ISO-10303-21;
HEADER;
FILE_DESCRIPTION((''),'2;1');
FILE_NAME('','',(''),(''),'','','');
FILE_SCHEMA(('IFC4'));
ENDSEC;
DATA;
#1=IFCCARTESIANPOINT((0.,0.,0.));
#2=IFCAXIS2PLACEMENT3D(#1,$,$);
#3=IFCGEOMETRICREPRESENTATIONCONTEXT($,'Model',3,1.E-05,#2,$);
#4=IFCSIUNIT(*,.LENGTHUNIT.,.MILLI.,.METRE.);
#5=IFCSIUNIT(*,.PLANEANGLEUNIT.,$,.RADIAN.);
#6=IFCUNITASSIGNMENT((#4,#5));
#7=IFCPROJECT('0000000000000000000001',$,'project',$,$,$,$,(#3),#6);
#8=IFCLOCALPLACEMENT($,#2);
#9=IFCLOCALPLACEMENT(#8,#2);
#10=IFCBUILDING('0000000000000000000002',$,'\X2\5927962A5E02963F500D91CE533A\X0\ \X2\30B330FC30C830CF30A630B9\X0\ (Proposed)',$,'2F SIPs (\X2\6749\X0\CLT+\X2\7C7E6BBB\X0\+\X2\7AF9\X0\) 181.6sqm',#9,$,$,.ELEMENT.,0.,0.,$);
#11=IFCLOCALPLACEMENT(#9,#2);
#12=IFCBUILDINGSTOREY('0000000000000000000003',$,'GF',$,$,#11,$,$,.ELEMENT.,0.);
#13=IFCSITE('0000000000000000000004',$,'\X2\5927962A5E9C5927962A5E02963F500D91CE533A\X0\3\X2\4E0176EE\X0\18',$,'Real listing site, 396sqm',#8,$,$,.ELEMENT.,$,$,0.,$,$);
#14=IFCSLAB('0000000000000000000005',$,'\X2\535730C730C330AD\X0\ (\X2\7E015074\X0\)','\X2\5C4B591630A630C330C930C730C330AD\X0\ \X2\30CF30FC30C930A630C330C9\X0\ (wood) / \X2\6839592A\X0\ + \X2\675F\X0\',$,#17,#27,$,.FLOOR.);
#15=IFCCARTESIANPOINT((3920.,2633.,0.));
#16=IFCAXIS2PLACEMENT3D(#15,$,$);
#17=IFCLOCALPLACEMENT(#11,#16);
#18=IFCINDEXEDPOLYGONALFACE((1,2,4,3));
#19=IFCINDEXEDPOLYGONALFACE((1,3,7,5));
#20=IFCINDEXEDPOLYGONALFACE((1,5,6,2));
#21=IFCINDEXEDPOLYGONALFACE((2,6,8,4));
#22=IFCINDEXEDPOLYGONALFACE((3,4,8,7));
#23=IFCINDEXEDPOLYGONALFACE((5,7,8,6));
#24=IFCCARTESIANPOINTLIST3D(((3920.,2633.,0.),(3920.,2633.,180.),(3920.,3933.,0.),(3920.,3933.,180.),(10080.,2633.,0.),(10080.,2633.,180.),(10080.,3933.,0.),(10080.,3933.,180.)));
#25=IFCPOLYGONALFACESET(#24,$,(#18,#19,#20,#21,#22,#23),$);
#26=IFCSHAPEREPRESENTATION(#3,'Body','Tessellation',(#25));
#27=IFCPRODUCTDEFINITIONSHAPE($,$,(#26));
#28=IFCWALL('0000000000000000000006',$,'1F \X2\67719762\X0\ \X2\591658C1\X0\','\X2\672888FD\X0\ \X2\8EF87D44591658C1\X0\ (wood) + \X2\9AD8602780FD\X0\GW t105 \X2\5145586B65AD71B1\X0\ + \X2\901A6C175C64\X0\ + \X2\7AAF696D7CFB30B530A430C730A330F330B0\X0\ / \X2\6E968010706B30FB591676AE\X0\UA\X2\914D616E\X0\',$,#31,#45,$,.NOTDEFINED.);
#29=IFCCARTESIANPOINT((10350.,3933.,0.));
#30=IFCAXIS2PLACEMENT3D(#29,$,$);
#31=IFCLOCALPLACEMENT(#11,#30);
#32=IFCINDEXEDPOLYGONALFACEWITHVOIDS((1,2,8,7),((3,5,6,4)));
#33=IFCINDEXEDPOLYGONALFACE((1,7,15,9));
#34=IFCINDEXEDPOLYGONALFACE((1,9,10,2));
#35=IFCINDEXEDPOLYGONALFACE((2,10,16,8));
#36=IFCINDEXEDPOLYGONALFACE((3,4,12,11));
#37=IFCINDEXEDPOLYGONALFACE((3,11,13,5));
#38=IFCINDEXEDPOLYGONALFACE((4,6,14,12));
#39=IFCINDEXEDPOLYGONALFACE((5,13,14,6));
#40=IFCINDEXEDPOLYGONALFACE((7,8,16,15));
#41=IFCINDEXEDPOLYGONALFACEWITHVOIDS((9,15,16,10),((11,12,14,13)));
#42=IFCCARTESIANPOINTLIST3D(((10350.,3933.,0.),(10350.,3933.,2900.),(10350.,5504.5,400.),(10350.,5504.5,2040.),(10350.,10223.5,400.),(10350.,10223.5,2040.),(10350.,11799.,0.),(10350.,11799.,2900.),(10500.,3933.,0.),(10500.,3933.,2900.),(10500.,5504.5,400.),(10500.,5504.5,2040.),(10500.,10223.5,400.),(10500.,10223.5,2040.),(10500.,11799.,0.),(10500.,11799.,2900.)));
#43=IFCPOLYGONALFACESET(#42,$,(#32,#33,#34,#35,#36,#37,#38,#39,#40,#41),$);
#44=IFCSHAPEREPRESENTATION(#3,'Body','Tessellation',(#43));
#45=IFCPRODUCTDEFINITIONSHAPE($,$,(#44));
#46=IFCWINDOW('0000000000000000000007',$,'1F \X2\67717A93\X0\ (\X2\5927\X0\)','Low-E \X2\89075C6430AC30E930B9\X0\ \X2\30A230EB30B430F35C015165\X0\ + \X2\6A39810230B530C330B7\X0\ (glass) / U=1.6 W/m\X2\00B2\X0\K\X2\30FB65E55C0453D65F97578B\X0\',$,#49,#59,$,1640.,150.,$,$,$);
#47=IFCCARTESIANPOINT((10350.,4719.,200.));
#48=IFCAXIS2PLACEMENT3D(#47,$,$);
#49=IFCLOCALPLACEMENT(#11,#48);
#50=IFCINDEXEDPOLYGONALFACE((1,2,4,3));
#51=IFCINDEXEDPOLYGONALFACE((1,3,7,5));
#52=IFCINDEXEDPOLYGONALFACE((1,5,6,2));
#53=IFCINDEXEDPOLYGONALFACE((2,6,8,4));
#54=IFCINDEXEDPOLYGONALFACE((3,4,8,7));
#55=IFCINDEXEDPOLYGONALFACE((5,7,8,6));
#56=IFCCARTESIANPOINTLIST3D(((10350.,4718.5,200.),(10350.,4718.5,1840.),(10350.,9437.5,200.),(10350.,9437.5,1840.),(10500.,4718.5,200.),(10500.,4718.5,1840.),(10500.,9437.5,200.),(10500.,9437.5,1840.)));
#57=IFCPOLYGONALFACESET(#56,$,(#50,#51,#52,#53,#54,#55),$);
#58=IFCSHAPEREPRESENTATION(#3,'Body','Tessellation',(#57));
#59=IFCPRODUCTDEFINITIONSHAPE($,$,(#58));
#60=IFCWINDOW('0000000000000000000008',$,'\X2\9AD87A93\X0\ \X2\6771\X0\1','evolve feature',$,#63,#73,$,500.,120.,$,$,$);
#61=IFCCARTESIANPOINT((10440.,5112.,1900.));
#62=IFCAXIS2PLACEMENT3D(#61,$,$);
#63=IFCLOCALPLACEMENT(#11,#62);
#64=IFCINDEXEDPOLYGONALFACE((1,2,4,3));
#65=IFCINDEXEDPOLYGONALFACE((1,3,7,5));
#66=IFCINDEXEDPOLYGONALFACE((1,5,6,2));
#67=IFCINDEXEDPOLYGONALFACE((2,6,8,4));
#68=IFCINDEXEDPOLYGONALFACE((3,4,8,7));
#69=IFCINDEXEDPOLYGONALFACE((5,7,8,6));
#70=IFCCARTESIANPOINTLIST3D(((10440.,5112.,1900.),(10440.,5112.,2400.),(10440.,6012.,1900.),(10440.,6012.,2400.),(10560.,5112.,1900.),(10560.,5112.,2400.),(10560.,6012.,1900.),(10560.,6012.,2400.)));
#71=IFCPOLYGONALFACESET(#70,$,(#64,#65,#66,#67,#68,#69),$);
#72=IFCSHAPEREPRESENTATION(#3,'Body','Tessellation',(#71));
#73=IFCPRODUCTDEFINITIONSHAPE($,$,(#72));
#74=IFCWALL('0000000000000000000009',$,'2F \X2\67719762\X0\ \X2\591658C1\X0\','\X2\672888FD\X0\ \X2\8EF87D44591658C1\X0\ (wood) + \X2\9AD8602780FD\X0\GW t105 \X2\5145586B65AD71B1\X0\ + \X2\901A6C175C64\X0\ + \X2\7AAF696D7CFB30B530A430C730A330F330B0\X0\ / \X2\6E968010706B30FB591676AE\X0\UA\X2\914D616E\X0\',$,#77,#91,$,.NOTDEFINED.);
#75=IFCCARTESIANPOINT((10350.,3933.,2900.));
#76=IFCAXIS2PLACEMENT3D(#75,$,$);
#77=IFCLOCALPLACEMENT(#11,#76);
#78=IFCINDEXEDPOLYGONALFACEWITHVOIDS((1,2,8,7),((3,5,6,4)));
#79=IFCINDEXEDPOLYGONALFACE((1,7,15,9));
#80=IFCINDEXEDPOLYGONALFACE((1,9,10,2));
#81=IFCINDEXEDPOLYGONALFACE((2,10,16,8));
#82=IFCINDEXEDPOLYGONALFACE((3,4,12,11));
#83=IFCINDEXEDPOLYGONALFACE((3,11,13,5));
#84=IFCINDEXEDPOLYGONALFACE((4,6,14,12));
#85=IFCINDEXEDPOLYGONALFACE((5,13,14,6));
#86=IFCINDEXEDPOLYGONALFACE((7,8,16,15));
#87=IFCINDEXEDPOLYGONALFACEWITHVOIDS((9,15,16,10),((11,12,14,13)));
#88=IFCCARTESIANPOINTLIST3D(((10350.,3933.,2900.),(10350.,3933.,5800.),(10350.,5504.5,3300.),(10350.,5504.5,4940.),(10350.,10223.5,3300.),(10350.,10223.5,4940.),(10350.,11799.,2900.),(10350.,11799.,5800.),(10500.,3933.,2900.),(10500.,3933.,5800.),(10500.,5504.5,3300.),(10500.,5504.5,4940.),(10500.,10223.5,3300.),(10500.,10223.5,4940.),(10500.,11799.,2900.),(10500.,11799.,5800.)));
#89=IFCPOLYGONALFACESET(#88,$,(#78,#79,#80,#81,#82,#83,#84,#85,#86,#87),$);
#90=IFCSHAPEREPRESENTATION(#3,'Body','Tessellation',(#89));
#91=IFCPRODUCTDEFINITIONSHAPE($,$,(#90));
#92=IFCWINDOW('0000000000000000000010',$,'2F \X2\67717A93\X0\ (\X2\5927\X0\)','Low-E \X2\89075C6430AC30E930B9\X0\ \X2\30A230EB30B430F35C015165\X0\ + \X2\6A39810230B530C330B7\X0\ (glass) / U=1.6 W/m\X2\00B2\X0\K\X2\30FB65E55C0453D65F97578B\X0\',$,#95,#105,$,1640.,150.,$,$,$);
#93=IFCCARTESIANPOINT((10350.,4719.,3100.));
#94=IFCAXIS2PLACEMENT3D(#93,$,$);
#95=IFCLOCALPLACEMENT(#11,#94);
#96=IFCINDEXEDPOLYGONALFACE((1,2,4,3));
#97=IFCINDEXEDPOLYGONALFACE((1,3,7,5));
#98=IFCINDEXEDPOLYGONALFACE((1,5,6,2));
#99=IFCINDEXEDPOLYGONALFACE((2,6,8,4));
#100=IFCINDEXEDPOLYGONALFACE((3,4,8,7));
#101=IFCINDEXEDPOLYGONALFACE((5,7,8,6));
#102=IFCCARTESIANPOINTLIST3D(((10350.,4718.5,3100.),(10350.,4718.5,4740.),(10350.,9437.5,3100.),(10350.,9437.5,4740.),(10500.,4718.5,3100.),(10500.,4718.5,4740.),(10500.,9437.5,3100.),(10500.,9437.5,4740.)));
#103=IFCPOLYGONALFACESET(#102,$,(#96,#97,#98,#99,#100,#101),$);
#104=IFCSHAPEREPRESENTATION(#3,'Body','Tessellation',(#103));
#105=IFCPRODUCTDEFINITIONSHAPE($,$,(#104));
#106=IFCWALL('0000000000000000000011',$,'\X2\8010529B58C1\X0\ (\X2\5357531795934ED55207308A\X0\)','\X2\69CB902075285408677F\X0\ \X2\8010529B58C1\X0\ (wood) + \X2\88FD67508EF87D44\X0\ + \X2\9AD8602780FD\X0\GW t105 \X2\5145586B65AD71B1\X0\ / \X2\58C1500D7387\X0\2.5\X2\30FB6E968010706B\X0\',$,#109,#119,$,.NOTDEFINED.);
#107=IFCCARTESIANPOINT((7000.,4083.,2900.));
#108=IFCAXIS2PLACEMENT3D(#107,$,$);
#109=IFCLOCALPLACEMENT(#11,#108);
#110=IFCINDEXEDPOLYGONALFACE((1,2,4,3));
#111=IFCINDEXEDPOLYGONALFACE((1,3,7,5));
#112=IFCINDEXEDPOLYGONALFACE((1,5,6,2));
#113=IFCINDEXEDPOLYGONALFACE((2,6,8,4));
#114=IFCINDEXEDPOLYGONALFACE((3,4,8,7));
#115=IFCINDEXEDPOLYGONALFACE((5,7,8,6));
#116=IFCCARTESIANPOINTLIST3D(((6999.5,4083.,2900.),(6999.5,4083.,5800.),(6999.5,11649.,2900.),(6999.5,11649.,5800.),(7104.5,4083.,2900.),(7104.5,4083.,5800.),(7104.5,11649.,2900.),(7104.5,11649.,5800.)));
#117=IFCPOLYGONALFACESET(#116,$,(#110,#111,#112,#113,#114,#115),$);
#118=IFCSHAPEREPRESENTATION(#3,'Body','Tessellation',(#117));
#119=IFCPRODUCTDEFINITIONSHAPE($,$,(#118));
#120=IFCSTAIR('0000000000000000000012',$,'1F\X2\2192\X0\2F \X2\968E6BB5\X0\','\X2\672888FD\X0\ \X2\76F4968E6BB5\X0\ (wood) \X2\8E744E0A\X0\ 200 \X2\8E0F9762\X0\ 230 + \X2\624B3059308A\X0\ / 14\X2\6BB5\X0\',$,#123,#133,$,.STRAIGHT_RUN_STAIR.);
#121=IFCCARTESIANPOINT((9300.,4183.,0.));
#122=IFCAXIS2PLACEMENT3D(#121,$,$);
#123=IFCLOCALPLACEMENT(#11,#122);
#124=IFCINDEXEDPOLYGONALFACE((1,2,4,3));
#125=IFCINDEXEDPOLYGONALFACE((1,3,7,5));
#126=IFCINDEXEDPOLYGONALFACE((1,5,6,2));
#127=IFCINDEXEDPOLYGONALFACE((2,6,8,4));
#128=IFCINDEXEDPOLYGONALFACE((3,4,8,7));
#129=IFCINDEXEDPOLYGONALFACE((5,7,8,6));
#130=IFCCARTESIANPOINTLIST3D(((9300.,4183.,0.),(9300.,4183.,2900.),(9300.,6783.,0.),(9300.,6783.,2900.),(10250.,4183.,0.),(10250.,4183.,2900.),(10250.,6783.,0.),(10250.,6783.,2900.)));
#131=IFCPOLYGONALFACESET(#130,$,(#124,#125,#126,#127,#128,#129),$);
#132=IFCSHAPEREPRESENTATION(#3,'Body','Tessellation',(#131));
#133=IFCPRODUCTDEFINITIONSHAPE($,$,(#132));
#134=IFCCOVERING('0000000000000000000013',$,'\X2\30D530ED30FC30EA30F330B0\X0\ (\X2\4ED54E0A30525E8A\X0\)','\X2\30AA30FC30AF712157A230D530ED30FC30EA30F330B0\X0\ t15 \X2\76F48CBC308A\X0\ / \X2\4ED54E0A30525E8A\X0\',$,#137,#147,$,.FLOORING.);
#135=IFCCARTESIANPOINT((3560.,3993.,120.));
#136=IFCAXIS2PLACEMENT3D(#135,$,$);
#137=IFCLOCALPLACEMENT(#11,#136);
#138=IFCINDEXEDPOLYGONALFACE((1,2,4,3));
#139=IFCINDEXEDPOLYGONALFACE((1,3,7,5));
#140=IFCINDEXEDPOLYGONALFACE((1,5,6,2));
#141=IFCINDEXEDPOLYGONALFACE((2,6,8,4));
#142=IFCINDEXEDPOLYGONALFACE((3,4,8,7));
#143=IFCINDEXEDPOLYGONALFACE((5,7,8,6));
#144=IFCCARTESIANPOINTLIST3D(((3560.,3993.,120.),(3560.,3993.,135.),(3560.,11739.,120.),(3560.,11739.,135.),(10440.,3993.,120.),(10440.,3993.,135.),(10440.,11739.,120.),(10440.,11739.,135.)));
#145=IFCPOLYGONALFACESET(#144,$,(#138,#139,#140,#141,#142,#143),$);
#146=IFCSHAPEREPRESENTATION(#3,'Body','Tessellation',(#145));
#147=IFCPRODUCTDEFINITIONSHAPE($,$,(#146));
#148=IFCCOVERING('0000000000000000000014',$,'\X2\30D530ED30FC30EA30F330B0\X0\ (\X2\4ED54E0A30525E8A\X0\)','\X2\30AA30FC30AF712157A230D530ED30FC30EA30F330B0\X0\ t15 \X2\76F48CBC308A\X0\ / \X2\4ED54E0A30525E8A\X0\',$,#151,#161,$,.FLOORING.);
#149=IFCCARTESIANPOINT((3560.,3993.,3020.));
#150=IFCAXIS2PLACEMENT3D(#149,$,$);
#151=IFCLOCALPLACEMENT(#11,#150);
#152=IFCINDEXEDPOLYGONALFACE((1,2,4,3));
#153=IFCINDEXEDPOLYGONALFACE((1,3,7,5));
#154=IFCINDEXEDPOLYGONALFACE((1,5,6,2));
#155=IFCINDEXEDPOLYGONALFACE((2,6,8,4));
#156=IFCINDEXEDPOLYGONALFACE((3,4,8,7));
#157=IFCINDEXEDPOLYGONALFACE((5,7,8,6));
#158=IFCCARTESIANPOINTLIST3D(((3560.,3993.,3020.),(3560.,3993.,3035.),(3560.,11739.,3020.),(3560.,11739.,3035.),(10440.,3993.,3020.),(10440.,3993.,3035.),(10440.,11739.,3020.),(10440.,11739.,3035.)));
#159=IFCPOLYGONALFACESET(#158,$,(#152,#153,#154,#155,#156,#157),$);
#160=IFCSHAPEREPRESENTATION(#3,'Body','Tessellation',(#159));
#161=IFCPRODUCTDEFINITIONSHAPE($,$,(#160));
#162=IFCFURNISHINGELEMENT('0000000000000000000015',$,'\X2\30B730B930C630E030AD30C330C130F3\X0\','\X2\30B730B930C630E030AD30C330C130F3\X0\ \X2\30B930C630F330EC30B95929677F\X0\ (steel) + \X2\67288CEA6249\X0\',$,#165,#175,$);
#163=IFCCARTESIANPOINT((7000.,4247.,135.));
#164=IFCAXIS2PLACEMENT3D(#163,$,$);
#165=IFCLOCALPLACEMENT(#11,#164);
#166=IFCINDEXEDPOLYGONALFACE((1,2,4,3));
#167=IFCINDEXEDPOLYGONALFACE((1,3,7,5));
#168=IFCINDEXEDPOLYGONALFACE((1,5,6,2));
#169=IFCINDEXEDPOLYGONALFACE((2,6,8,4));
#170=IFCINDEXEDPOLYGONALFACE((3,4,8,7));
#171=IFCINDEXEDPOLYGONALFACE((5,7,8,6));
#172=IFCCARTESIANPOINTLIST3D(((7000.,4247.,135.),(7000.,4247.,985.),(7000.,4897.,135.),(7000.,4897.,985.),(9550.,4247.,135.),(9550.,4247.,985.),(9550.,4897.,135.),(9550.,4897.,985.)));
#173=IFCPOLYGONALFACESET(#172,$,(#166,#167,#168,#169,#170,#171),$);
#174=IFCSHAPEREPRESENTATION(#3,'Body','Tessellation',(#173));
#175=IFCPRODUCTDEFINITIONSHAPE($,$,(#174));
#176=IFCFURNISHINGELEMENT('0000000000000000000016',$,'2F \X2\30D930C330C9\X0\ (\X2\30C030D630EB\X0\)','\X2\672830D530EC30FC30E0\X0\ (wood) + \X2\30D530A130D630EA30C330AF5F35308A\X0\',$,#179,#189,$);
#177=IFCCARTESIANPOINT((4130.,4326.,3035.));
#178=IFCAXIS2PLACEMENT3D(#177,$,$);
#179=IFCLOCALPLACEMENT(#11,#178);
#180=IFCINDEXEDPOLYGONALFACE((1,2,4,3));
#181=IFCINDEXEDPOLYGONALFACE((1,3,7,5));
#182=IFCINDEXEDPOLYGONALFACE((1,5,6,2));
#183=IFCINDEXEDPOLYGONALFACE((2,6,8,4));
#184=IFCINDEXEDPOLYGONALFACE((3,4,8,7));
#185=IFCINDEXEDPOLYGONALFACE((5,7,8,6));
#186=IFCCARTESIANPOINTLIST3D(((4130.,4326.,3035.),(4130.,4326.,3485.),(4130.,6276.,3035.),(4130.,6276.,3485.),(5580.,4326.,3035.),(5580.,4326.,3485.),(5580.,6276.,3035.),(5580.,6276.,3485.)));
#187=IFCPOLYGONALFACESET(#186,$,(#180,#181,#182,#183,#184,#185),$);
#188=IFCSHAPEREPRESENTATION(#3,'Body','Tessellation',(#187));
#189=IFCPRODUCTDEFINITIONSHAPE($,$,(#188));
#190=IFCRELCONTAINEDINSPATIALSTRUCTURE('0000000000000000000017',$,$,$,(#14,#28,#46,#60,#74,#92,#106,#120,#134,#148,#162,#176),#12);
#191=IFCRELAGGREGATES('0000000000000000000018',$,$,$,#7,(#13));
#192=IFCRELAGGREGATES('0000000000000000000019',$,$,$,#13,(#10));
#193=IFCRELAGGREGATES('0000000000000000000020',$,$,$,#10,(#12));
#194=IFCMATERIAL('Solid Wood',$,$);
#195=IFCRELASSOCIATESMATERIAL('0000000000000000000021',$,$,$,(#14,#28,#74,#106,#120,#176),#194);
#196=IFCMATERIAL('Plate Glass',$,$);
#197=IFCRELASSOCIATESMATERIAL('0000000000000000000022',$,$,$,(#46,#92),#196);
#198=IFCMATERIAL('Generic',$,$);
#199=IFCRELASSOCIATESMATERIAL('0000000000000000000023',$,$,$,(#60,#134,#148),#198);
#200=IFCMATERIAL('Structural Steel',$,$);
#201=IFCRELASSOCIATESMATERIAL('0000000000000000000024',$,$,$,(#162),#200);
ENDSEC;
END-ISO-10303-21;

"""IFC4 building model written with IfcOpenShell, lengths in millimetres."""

from ifc_helpers import new_model, si_unit, frame, frame_2d, origin, place, context, project, spatial, rectangle, extrude, material, element, fill, save


model = new_model("IFC4")

# Units and contexts
model_context = context("Model", 3, precision=1e-05, world=origin())
ifc_project = project(units=[si_unit("LENGTHUNIT", "METRE", prefix="MILLI"), si_unit("PLANEANGLEUNIT", "RADIAN")], contexts=[model_context])

# Site, building, storey
site_placement = place(None, origin())
site = spatial("IfcSite", under=ifc_project, at=site_placement, Name="大阪府大阪市阿倍野区3丁目18", ObjectType="Real listing site, 396sqm", CompositionType="ELEMENT", RefElevation=0.0)
building_placement = place(site_placement, origin())
building = spatial("IfcBuilding", under=site, at=building_placement, Name="大阪市阿倍野区 コートハウス (Proposed)", ObjectType="2F SIPs (杉CLT+籾殻+竹) 181.6sqm", CompositionType="ELEMENT", ElevationOfRefHeight=0.0, ElevationOfTerrain=0.0)
storey_placement = place(building_placement, origin())
storey = spatial("IfcBuildingStorey", under=building, at=storey_placement, Name="GF", CompositionType="ELEMENT", Elevation=0.0)

# Slab
ifc_material_1 = material(Name="Solid Wood")
slab_placement = place(storey_placement, frame((3920.0, 2633.0, 0.0)))
element("IfcSlab", 1, at=slab_placement, inside=storey, material=ifc_material_1, Name="南デッキ (縁側)", Description="屋外ウッドデッキ ハードウッド (wood) / 根太 + 束", PredefinedType="FLOOR", context=model_context, shape_type="SweptSolid", body=[
    extrude(rectangle(XDim=6160.0, YDim=1300.0, at=frame_2d((3080.0, 650.0))), frame((3920.0, 2633.0, 0.0)), (0.0, 0.0, 1.0), 180.0),
])

# Wall, openings, windows
wall_1_placement = place(storey_placement, frame((10350.0, 3933.0, 0.0)))
wall_1 = element("IfcWall", 2, at=wall_1_placement, inside=storey, material=ifc_material_1, Name="1F 東面 外壁", Description="木製 軸組外壁 (wood) + 高性能GW t105 充填断熱 + 通気層 + 窯業系サイディング / 準耐火・外皮UA配慮", PredefinedType="NOTDEFINED", context=model_context, shape_type="SweptSolid", body=[
    extrude(rectangle(XDim=150.0, YDim=7866.0, at=frame_2d((75.0, 3933.0))), frame((10350.0, 3933.0, 0.0)), (0.0, 0.0, 1.0), 2900.0),
])
opening_1_placement = place(storey_placement, frame((10350.0, 4719.0, 200.0)))
opening_1 = element("IfcOpeningElement", 3, at=opening_1_placement, cuts=wall_1, PredefinedType="NOTDEFINED", context=model_context, shape_type="SweptSolid", body=[
    extrude(rectangle(XDim=150.0, YDim=4719.0, at=frame_2d((75.0, 2359.0))), frame((10350.0, 4719.0, 200.0)), (0.0, 0.0, 1.0), 1640.0),
])
opening_2_placement = place(storey_placement, frame((10440.0, 5112.0, 1900.0)))
opening_2 = element("IfcOpeningElement", 4, at=opening_2_placement, cuts=wall_1, PredefinedType="NOTDEFINED", context=model_context, shape_type="SweptSolid", body=[
    extrude(rectangle(XDim=120.0, YDim=900.0, at=frame_2d((60.0, 450.0))), frame((10440.0, 5112.0, 1900.0)), (0.0, 0.0, 1.0), 500.0),
])
ifc_material_2 = material(Name="Plate Glass")
window_1_placement = place(storey_placement, frame((10350.0, 4719.0, 200.0)))
window_1 = element("IfcWindow", 5, at=window_1_placement, inside=storey, material=ifc_material_2, Name="1F 東窓 (大)", Description="Low-E 複層ガラス アルゴン封入 + 樹脂サッシ (glass) / U=1.6 W/m²K・日射取得型", OverallHeight=1640.0, OverallWidth=150.0, context=model_context, shape_type="SweptSolid", body=[
    extrude(rectangle(XDim=150.0, YDim=4719.0, at=frame_2d((75.0, 2359.0))), frame((10350.0, 4719.0, 200.0)), (0.0, 0.0, 1.0), 1640.0),
])
fill(opening_1, window_1)
ifc_material_3 = material(Name="Generic")
window_2_placement = place(storey_placement, frame((10440.0, 5112.0, 1900.0)))
window_2 = element("IfcWindow", 6, at=window_2_placement, inside=storey, material=ifc_material_3, Name="高窓 東1", Description="evolve feature", OverallHeight=500.0, OverallWidth=120.0, context=model_context, shape_type="SweptSolid", body=[
    extrude(rectangle(XDim=120.0, YDim=900.0, at=frame_2d((60.0, 450.0))), frame((10440.0, 5112.0, 1900.0)), (0.0, 0.0, 1.0), 500.0),
])
fill(opening_2, window_2)

# Wall, opening, window
wall_2_placement = place(storey_placement, frame((10350.0, 3933.0, 2900.0)))
wall_2 = element("IfcWall", 7, at=wall_2_placement, inside=storey, material=ifc_material_1, Name="2F 東面 外壁", Description="木製 軸組外壁 (wood) + 高性能GW t105 充填断熱 + 通気層 + 窯業系サイディング / 準耐火・外皮UA配慮", PredefinedType="NOTDEFINED", context=model_context, shape_type="SweptSolid", body=[
    extrude(rectangle(XDim=150.0, YDim=7866.0, at=frame_2d((75.0, 3933.0))), frame((10350.0, 3933.0, 2900.0)), (0.0, 0.0, 1.0), 2900.0),
])
opening_3_placement = place(storey_placement, frame((10350.0, 4719.0, 3100.0)))
opening_3 = element("IfcOpeningElement", 8, at=opening_3_placement, cuts=wall_2, PredefinedType="NOTDEFINED", context=model_context, shape_type="SweptSolid", body=[
    extrude(rectangle(XDim=150.0, YDim=4719.0, at=frame_2d((75.0, 2359.0))), frame((10350.0, 4719.0, 3100.0)), (0.0, 0.0, 1.0), 1640.0),
])
window_3_placement = place(storey_placement, frame((10350.0, 4719.0, 3100.0)))
window_3 = element("IfcWindow", 9, at=window_3_placement, inside=storey, material=ifc_material_2, Name="2F 東窓 (大)", Description="Low-E 複層ガラス アルゴン封入 + 樹脂サッシ (glass) / U=1.6 W/m²K・日射取得型", OverallHeight=1640.0, OverallWidth=150.0, context=model_context, shape_type="SweptSolid", body=[
    extrude(rectangle(XDim=150.0, YDim=4719.0, at=frame_2d((75.0, 2359.0))), frame((10350.0, 4719.0, 3100.0)), (0.0, 0.0, 1.0), 1640.0),
])
fill(opening_3, window_3)

# Wall
wall_3_placement = place(storey_placement, frame((7000.0, 4083.0, 2900.0)))
element("IfcWall", 10, at=wall_3_placement, inside=storey, material=ifc_material_1, Name="耐力壁 (南北間仕切り)", Description="構造用合板 耐力壁 (wood) + 製材軸組 + 高性能GW t105 充填断熱 / 壁倍率2.5・準耐火", PredefinedType="NOTDEFINED", context=model_context, shape_type="SweptSolid", body=[
    extrude(rectangle(XDim=105.0, YDim=7566.0, at=frame_2d((52.0, 3783.0))), frame((7000.0, 4083.0, 2900.0)), (0.0, 0.0, 1.0), 2900.0),
])

# Stair
stair_placement = place(storey_placement, frame((9300.0, 4183.0, 0.0)))
element("IfcStair", 11, at=stair_placement, inside=storey, material=ifc_material_1, Name="1F→2F 階段", Description="木製 直階段 (wood) 蹴上 200 踏面 230 + 手すり / 14段", PredefinedType="STRAIGHT_RUN_STAIR", context=model_context, shape_type="SweptSolid", body=[
    extrude(rectangle(XDim=950.0, YDim=2600.0, at=frame_2d((475.0, 1300.0))), frame((9300.0, 4183.0, 0.0)), (0.0, 0.0, 1.0), 2900.0),
])

# Coverings
covering_1_placement = place(storey_placement, frame((3560.0, 3993.0, 120.0)))
element("IfcCovering", 12, at=covering_1_placement, inside=storey, material=ifc_material_3, Name="フローリング (仕上げ床)", Description="オーク無垢フローリング t15 直貼り / 仕上げ床", PredefinedType="FLOORING", context=model_context, shape_type="SweptSolid", body=[
    extrude(rectangle(XDim=6880.0, YDim=7746.0, at=frame_2d((3440.0, 3873.0))), frame((3560.0, 3993.0, 120.0)), (0.0, 0.0, 1.0), 15.0),
])
covering_2_placement = place(storey_placement, frame((3560.0, 3993.0, 3020.0)))
element("IfcCovering", 13, at=covering_2_placement, inside=storey, material=ifc_material_3, Name="フローリング (仕上げ床)", Description="オーク無垢フローリング t15 直貼り / 仕上げ床", PredefinedType="FLOORING", context=model_context, shape_type="SweptSolid", body=[
    extrude(rectangle(XDim=6880.0, YDim=7746.0, at=frame_2d((3440.0, 3873.0))), frame((3560.0, 3993.0, 3020.0)), (0.0, 0.0, 1.0), 15.0),
])

# Furnishing elements
ifc_material_4 = material(Name="Structural Steel")
furnishing_1_placement = place(storey_placement, frame((7000.0, 4247.0, 135.0)))
element("IfcFurnishingElement", 14, at=furnishing_1_placement, inside=storey, material=ifc_material_4, Name="システムキッチン", Description="システムキッチン ステンレス天板 (steel) + 木質扉", context=model_context, shape_type="SweptSolid", body=[
    extrude(rectangle(XDim=2550.0, YDim=650.0, at=frame_2d((1275.0, 325.0))), frame((7000.0, 4247.0, 135.0)), (0.0, 0.0, 1.0), 850.0),
])
furnishing_2_placement = place(storey_placement, frame((4130.0, 4326.0, 3035.0)))
element("IfcFurnishingElement", 15, at=furnishing_2_placement, inside=storey, material=ifc_material_1, Name="2F ベッド (ダブル)", Description="木フレーム (wood) + ファブリック張り", context=model_context, shape_type="SweptSolid", body=[
    extrude(rectangle(XDim=1450.0, YDim=1950.0, at=frame_2d((725.0, 975.0))), frame((4130.0, 4326.0, 3035.0)), (0.0, 0.0, 1.0), 450.0),
])

save(model, "model.ifc")
